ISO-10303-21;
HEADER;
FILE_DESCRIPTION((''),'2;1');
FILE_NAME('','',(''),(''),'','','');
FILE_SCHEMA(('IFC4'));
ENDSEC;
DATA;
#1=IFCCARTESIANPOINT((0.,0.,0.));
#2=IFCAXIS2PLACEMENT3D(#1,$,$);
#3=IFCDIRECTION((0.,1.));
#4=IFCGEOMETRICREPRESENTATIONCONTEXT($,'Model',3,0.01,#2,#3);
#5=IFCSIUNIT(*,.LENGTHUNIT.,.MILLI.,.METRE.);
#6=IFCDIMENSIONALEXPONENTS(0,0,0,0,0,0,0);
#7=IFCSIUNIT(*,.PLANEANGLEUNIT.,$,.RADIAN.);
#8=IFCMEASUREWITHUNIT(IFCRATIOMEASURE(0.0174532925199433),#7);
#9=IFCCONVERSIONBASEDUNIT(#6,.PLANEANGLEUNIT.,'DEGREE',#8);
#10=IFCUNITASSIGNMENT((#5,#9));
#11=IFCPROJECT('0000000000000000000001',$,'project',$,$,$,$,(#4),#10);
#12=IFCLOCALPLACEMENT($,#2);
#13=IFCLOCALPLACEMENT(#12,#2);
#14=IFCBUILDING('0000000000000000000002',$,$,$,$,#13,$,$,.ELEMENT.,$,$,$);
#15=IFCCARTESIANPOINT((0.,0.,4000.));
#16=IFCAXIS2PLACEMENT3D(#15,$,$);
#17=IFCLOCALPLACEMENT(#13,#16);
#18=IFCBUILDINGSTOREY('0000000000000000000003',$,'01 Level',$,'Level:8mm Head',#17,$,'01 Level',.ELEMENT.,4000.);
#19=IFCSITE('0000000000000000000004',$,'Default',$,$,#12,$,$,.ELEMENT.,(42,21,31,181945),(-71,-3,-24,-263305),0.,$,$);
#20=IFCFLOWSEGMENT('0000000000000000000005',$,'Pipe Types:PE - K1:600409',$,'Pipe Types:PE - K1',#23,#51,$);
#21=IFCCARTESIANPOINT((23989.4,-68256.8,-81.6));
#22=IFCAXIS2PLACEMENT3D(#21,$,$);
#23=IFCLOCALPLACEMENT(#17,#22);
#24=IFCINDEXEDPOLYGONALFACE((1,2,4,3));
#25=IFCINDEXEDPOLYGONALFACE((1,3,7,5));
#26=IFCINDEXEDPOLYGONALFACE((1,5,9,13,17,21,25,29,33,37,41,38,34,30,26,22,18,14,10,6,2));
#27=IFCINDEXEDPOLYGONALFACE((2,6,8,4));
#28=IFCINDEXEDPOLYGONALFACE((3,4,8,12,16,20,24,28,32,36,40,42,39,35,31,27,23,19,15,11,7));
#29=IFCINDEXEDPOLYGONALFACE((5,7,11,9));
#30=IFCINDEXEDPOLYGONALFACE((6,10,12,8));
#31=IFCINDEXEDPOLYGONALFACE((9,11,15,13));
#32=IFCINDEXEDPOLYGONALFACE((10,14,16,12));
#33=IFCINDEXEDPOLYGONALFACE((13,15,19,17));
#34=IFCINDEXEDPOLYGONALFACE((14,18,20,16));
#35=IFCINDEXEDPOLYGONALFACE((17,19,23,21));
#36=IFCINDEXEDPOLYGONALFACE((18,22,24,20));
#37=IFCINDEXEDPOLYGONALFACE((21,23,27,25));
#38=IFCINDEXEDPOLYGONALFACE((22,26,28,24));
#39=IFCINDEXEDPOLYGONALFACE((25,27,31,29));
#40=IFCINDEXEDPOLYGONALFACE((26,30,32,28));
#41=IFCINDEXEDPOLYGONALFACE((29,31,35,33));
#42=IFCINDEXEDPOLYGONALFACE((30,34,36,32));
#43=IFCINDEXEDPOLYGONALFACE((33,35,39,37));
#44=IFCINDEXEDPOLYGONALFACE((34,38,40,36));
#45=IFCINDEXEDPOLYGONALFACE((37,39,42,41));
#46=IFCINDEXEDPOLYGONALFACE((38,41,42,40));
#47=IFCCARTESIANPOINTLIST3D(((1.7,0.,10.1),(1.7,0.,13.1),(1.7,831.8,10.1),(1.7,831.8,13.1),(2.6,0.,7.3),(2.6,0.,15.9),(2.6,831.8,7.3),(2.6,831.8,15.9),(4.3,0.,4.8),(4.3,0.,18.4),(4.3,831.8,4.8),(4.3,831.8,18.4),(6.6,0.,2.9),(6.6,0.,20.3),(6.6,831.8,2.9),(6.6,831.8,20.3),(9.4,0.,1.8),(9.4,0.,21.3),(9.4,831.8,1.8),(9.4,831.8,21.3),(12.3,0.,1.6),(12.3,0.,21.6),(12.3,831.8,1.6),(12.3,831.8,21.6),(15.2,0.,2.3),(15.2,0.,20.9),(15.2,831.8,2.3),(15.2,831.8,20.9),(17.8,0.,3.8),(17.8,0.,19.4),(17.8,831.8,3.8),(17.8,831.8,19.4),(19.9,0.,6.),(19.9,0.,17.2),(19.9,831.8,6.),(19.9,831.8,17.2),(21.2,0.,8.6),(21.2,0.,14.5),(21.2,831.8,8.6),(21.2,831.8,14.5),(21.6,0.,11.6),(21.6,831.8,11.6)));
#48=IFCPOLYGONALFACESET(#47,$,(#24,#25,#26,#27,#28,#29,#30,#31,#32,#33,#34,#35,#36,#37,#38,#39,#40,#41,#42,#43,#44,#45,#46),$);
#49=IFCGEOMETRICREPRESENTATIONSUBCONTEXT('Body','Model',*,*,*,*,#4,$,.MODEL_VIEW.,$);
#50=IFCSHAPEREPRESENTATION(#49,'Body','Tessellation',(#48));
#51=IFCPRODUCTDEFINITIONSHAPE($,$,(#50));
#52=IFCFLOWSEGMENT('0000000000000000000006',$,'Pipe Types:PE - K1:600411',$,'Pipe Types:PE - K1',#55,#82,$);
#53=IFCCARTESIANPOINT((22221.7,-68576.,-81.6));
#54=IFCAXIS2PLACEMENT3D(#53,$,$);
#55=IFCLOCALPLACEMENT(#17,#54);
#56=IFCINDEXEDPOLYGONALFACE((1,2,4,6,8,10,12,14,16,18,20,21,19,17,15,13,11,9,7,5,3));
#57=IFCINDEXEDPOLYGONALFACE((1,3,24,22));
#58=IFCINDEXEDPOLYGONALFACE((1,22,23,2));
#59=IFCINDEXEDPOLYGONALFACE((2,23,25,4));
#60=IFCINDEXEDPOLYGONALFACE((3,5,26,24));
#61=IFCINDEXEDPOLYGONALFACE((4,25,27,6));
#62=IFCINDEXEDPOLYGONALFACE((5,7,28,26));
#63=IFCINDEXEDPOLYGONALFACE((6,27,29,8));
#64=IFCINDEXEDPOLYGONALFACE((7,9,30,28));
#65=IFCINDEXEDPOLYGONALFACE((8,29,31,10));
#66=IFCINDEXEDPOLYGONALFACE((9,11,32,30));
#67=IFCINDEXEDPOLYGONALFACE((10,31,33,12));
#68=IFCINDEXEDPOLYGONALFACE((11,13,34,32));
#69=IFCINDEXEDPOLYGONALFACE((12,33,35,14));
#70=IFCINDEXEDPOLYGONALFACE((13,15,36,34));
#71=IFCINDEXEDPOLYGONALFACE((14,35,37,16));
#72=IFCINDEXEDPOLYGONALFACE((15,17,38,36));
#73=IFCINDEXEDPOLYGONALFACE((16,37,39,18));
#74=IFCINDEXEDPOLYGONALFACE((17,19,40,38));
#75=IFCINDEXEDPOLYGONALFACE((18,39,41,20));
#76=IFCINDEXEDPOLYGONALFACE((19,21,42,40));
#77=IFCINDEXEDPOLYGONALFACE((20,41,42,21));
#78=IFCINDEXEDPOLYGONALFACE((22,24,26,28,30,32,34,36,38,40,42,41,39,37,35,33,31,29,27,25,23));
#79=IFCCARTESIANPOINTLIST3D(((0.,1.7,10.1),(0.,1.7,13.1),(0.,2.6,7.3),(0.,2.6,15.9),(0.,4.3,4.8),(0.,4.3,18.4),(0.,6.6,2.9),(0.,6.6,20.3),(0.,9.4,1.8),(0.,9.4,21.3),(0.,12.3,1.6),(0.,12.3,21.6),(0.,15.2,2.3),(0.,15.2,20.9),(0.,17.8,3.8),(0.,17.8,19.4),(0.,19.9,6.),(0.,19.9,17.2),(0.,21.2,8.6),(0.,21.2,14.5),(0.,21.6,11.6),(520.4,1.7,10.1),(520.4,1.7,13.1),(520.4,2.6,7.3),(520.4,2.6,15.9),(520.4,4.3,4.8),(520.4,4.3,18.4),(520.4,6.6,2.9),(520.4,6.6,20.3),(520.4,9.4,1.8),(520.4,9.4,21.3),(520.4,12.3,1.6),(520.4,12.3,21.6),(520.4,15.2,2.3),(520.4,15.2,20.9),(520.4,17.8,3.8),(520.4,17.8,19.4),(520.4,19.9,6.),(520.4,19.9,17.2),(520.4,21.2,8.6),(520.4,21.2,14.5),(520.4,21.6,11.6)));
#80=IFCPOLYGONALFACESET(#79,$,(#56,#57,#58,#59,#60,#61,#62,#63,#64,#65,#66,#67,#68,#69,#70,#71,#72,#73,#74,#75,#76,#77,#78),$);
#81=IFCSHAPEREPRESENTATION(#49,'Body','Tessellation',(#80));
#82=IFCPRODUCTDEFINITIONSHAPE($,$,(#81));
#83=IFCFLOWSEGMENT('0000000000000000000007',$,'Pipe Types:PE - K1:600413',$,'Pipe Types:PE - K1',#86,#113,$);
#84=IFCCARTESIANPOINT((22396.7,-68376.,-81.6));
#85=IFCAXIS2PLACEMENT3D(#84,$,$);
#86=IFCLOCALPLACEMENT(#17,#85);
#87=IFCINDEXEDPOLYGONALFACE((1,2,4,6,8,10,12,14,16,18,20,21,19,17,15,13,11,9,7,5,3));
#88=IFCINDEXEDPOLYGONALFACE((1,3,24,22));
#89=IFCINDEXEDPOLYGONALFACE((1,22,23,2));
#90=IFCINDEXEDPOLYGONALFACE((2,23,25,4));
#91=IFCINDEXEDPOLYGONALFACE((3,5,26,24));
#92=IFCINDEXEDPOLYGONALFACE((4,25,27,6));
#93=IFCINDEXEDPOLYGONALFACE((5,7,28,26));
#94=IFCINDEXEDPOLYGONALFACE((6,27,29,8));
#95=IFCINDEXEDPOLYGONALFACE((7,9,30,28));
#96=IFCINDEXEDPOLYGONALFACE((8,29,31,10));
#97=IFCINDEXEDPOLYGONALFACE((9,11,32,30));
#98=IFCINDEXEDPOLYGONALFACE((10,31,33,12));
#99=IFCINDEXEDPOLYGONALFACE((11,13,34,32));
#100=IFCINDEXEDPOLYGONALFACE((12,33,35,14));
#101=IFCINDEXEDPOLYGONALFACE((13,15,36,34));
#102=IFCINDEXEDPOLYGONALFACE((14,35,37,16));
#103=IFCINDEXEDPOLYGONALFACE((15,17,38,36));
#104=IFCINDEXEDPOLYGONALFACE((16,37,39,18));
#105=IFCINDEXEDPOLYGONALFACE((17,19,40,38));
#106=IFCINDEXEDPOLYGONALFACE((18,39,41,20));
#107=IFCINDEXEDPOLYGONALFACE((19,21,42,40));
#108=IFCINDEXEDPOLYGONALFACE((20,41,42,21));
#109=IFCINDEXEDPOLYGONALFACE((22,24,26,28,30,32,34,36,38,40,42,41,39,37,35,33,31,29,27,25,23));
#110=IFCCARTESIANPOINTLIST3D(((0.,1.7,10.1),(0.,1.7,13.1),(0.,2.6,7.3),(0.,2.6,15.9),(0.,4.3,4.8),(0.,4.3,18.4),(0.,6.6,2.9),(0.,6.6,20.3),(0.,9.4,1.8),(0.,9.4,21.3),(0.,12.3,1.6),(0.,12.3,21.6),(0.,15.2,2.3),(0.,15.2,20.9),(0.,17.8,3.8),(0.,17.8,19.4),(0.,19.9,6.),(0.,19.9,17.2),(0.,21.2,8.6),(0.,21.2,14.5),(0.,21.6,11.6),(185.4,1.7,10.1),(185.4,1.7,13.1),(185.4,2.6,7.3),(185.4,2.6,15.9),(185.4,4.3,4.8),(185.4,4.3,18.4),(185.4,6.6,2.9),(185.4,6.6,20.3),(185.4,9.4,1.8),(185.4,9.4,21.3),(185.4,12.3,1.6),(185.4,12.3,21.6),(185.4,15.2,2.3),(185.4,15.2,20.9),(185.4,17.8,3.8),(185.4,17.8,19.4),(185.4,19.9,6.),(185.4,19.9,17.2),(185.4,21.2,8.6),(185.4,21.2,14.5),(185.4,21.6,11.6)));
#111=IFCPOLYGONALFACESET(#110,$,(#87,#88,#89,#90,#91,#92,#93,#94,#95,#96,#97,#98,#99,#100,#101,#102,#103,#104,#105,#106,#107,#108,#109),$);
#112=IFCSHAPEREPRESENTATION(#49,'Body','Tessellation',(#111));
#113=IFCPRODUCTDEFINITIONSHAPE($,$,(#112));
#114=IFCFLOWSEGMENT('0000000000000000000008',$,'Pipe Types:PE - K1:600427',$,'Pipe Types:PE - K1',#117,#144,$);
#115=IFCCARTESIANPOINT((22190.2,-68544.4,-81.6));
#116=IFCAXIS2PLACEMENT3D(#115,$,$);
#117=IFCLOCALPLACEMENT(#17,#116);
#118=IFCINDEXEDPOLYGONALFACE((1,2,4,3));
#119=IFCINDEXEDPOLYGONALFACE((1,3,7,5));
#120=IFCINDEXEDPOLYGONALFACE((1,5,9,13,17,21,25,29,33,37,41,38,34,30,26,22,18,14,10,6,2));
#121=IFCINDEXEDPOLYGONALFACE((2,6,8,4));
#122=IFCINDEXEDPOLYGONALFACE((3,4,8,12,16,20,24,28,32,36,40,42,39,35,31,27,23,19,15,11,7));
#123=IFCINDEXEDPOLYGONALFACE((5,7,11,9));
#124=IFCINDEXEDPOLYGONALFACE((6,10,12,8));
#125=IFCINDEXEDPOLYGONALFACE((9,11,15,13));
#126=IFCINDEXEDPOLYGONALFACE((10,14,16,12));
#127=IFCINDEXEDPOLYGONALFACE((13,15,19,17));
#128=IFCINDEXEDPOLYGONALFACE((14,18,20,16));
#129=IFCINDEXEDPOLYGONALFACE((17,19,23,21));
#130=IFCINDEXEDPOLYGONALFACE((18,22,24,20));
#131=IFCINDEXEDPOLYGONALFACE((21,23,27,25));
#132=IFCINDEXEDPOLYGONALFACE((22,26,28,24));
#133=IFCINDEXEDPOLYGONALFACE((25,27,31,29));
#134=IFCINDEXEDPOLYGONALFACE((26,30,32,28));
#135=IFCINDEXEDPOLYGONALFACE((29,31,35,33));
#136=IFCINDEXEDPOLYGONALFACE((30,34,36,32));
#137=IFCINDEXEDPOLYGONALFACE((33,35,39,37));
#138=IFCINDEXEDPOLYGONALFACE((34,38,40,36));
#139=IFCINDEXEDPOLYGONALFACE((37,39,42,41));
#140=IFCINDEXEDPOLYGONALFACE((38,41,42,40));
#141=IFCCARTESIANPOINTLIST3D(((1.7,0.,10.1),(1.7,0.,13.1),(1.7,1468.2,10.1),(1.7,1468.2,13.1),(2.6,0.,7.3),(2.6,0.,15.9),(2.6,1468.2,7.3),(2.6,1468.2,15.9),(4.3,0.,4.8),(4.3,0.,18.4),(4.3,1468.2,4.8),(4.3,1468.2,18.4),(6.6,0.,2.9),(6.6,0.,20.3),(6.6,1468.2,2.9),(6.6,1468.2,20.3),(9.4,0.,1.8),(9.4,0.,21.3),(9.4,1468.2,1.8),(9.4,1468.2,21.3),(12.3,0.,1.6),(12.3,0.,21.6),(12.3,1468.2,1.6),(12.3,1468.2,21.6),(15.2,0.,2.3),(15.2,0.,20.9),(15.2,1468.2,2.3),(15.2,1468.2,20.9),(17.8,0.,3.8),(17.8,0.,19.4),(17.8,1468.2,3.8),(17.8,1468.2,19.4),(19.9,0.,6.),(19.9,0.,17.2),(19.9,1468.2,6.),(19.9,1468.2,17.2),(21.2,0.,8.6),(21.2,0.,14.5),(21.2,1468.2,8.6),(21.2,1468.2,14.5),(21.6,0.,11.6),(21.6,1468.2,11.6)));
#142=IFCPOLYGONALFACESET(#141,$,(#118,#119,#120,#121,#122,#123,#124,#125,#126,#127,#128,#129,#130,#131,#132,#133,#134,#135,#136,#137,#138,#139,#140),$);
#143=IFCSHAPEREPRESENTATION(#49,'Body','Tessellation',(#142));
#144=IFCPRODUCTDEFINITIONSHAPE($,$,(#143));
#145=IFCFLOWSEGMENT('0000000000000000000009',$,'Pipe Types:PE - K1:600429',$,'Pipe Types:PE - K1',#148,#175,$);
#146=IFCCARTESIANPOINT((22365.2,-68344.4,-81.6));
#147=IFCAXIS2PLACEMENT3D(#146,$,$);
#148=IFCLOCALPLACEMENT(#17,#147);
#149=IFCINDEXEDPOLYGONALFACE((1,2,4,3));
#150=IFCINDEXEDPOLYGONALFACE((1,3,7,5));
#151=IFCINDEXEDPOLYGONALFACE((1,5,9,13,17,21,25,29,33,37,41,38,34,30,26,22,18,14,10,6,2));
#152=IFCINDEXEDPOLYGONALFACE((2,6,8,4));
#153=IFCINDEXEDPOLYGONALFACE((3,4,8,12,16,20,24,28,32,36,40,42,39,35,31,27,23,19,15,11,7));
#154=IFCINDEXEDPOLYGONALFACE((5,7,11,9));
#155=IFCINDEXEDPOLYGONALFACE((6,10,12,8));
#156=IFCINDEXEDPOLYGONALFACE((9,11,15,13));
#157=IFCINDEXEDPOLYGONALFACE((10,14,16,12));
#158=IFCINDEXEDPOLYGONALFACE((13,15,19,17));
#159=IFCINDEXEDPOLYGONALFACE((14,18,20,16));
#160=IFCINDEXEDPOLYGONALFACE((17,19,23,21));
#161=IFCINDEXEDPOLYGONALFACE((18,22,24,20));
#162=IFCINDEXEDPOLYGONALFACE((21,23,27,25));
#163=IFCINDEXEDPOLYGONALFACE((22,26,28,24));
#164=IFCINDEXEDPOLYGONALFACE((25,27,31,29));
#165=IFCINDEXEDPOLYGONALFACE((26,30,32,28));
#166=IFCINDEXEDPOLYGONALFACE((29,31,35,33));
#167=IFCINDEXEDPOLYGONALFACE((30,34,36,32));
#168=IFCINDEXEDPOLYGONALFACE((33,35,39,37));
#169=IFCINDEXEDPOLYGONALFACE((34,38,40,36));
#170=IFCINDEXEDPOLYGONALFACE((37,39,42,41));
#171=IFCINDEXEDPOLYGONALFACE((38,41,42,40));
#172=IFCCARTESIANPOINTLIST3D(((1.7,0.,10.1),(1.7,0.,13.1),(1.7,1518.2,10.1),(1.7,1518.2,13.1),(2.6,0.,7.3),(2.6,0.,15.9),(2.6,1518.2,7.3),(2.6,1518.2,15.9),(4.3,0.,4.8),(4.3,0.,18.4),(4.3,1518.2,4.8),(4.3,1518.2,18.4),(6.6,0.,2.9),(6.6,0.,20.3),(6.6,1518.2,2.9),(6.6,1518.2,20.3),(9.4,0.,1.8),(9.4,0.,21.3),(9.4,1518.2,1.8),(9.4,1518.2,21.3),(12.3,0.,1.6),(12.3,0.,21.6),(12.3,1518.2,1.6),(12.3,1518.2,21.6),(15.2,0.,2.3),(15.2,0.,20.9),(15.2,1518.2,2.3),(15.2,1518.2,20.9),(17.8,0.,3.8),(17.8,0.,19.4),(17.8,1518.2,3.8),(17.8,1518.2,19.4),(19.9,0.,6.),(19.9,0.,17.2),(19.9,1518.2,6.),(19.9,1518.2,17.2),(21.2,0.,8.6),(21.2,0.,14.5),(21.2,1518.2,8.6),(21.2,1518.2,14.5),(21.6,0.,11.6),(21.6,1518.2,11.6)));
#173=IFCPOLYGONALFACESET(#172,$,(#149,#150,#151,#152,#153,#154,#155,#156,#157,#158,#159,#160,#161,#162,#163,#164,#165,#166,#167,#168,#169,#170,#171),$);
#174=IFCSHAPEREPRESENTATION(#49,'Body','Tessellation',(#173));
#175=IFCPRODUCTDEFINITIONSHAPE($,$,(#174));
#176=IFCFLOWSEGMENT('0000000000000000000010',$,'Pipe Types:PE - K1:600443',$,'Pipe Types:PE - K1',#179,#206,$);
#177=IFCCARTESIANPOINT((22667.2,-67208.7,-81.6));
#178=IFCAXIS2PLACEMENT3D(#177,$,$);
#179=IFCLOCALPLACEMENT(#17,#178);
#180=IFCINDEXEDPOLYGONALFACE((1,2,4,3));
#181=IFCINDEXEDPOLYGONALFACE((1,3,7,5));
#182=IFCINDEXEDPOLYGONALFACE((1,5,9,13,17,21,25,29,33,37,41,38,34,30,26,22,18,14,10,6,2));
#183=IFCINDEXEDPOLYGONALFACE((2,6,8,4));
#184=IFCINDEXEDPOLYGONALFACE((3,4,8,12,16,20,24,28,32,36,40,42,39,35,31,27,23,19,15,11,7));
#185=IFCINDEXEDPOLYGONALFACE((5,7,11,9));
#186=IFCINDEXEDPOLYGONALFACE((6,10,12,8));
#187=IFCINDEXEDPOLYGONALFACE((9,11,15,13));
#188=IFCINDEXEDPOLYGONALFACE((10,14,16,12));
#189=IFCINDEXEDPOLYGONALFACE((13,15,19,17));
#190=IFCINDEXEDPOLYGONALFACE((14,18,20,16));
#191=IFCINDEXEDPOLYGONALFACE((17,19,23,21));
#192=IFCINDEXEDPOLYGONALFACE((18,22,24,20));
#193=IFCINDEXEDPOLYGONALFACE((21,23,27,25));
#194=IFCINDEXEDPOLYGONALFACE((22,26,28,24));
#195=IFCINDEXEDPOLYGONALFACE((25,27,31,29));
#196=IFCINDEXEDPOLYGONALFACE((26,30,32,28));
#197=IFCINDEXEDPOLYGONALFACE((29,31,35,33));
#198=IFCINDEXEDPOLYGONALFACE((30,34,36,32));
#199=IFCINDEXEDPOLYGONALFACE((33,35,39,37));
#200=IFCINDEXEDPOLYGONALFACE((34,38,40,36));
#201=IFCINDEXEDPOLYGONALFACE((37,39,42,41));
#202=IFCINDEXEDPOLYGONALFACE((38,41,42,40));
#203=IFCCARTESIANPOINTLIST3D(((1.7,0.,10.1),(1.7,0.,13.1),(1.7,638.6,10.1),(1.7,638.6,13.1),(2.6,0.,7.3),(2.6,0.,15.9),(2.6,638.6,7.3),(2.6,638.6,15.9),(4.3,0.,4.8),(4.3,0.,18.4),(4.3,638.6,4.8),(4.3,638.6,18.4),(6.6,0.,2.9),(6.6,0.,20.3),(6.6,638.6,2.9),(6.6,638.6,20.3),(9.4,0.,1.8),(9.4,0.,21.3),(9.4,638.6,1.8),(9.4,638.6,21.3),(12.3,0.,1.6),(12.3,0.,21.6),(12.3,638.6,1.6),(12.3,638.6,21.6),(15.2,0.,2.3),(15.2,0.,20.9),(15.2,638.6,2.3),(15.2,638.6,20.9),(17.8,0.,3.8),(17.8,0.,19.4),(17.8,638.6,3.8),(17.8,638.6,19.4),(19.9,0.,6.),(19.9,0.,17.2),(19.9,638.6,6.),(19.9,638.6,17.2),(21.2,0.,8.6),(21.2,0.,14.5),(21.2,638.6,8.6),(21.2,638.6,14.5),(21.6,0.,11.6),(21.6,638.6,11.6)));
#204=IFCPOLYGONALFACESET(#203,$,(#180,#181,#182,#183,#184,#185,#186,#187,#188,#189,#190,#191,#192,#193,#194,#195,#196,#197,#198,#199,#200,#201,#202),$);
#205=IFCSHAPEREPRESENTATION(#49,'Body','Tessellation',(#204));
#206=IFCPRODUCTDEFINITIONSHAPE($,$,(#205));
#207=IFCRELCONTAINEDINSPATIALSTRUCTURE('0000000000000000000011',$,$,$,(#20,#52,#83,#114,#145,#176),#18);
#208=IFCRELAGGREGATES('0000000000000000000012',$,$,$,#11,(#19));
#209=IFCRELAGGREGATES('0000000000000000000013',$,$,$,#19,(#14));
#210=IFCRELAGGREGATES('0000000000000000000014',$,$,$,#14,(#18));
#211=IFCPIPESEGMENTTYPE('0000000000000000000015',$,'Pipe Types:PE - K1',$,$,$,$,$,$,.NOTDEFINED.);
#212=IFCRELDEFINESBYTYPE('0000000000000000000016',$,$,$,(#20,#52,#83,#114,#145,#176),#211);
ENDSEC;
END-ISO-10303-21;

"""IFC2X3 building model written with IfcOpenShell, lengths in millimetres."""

from ifc_helpers import new_model, entity, si_unit, converted_unit, direction, frame, origin, origin_2d_with_axis, place, context, subcontext, project, spatial, circle, extrude, type_object, element, save


model = new_model("IFC2X3")

# Units and contexts
model_context = context("Model", 3, precision=0.01, world=origin(), true_north=direction((0.0, 1.0)))
body_context = subcontext(model_context, "Body", "Model", "MODEL_VIEW")
ifc_project = project(units=[si_unit("LENGTHUNIT", "METRE", prefix="MILLI"), converted_unit("PLANEANGLEUNIT", "DEGREE", entity("IfcRatioMeasure", 0.0174532925199433), si_unit("PLANEANGLEUNIT", "RADIAN"), dimensions=[0, 0, 0, 0, 0, 0, 0])], contexts=[model_context])

# Site, building, storey
site_placement = place(None, origin())
site = spatial("IfcSite", under=ifc_project, at=site_placement, Name="Default", CompositionType="ELEMENT", RefLatitude=(42, 21, 31, 181945), RefLongitude=(-71, -3, -24, -263305), RefElevation=0.0)
building_placement = place(site_placement, origin())
building = spatial("IfcBuilding", under=site, at=building_placement, CompositionType="ELEMENT")
storey_placement = place(building_placement, frame((0.0, 0.0, 4000.0)))
storey = spatial("IfcBuildingStorey", under=building, at=storey_placement, Name="01 Level", ObjectType="Level:8mm Head", LongName="01 Level", CompositionType="ELEMENT", Elevation=4000.0)

# Flow segments
pipe_segment_type = type_object("IfcPipeSegmentType", Name="Pipe Types:PE - K1", PredefinedType="NOTDEFINED")
flow_segment_1_placement = place(storey_placement, frame((23989.4, -68256.8, -81.6)))
element("IfcFlowSegment", 1, at=flow_segment_1_placement, inside=storey, type_object=pipe_segment_type, Name="Pipe Types:PE - K1:600409", ObjectType="Pipe Types:PE - K1", context=body_context, shape_type="SweptSolid", body=[
    extrude(circle(Radius=10.0, at=origin_2d_with_axis()), frame((11.6, 0.0, 11.6), z_axis=(0.0, 1.0, 0.0), x_axis=(1.0, 0.0, 0.0)), (0.0, 0.0, 1.0), 831.8),
])
flow_segment_2_placement = place(storey_placement, frame((22221.7, -68576.0, -81.6)))
element("IfcFlowSegment", 2, at=flow_segment_2_placement, inside=storey, type_object=pipe_segment_type, Name="Pipe Types:PE - K1:600411", ObjectType="Pipe Types:PE - K1", context=body_context, shape_type="SweptSolid", body=[
    extrude(circle(Radius=10.0, at=origin_2d_with_axis()), frame((0.0, 11.6, 11.6), z_axis=(1.0, 0.0, 0.0), x_axis=(0.0, 1.0, 0.0)), (0.0, 0.0, 1.0), 520.4),
])
flow_segment_3_placement = place(storey_placement, frame((22396.7, -68376.0, -81.6)))
element("IfcFlowSegment", 3, at=flow_segment_3_placement, inside=storey, type_object=pipe_segment_type, Name="Pipe Types:PE - K1:600413", ObjectType="Pipe Types:PE - K1", context=body_context, shape_type="SweptSolid", body=[
    extrude(circle(Radius=10.0, at=origin_2d_with_axis()), frame((0.0, 11.6, 11.6), z_axis=(1.0, 0.0, 0.0), x_axis=(0.0, 1.0, 0.0)), (0.0, 0.0, 1.0), 185.4),
])
flow_segment_4_placement = place(storey_placement, frame((22190.2, -68544.4, -81.6)))
element("IfcFlowSegment", 4, at=flow_segment_4_placement, inside=storey, type_object=pipe_segment_type, Name="Pipe Types:PE - K1:600427", ObjectType="Pipe Types:PE - K1", context=body_context, shape_type="SweptSolid", body=[
    extrude(circle(Radius=10.0, at=origin_2d_with_axis()), frame((11.6, 0.0, 11.6), z_axis=(0.0, 1.0, 0.0), x_axis=(1.0, 0.0, 0.0)), (0.0, 0.0, 1.0), 1468.2),
])
flow_segment_5_placement = place(storey_placement, frame((22365.2, -68344.4, -81.6)))
element("IfcFlowSegment", 5, at=flow_segment_5_placement, inside=storey, type_object=pipe_segment_type, Name="Pipe Types:PE - K1:600429", ObjectType="Pipe Types:PE - K1", context=body_context, shape_type="SweptSolid", body=[
    extrude(circle(Radius=10.0, at=origin_2d_with_axis()), frame((11.6, 0.0, 11.6), z_axis=(0.0, 1.0, 0.0), x_axis=(1.0, 0.0, 0.0)), (0.0, 0.0, 1.0), 1518.2),
])
flow_segment_6_placement = place(storey_placement, frame((22667.2, -67208.7, -81.6)))
element("IfcFlowSegment", 6, at=flow_segment_6_placement, inside=storey, type_object=pipe_segment_type, Name="Pipe Types:PE - K1:600443", ObjectType="Pipe Types:PE - K1", context=body_context, shape_type="SweptSolid", body=[
    extrude(circle(Radius=10.0, at=origin_2d_with_axis()), frame((11.6, 0.0, 11.6), z_axis=(0.0, 1.0, 0.0), x_axis=(1.0, 0.0, 0.0)), (0.0, 0.0, 1.0), 638.6),
])

save(model, "model.ifc")
